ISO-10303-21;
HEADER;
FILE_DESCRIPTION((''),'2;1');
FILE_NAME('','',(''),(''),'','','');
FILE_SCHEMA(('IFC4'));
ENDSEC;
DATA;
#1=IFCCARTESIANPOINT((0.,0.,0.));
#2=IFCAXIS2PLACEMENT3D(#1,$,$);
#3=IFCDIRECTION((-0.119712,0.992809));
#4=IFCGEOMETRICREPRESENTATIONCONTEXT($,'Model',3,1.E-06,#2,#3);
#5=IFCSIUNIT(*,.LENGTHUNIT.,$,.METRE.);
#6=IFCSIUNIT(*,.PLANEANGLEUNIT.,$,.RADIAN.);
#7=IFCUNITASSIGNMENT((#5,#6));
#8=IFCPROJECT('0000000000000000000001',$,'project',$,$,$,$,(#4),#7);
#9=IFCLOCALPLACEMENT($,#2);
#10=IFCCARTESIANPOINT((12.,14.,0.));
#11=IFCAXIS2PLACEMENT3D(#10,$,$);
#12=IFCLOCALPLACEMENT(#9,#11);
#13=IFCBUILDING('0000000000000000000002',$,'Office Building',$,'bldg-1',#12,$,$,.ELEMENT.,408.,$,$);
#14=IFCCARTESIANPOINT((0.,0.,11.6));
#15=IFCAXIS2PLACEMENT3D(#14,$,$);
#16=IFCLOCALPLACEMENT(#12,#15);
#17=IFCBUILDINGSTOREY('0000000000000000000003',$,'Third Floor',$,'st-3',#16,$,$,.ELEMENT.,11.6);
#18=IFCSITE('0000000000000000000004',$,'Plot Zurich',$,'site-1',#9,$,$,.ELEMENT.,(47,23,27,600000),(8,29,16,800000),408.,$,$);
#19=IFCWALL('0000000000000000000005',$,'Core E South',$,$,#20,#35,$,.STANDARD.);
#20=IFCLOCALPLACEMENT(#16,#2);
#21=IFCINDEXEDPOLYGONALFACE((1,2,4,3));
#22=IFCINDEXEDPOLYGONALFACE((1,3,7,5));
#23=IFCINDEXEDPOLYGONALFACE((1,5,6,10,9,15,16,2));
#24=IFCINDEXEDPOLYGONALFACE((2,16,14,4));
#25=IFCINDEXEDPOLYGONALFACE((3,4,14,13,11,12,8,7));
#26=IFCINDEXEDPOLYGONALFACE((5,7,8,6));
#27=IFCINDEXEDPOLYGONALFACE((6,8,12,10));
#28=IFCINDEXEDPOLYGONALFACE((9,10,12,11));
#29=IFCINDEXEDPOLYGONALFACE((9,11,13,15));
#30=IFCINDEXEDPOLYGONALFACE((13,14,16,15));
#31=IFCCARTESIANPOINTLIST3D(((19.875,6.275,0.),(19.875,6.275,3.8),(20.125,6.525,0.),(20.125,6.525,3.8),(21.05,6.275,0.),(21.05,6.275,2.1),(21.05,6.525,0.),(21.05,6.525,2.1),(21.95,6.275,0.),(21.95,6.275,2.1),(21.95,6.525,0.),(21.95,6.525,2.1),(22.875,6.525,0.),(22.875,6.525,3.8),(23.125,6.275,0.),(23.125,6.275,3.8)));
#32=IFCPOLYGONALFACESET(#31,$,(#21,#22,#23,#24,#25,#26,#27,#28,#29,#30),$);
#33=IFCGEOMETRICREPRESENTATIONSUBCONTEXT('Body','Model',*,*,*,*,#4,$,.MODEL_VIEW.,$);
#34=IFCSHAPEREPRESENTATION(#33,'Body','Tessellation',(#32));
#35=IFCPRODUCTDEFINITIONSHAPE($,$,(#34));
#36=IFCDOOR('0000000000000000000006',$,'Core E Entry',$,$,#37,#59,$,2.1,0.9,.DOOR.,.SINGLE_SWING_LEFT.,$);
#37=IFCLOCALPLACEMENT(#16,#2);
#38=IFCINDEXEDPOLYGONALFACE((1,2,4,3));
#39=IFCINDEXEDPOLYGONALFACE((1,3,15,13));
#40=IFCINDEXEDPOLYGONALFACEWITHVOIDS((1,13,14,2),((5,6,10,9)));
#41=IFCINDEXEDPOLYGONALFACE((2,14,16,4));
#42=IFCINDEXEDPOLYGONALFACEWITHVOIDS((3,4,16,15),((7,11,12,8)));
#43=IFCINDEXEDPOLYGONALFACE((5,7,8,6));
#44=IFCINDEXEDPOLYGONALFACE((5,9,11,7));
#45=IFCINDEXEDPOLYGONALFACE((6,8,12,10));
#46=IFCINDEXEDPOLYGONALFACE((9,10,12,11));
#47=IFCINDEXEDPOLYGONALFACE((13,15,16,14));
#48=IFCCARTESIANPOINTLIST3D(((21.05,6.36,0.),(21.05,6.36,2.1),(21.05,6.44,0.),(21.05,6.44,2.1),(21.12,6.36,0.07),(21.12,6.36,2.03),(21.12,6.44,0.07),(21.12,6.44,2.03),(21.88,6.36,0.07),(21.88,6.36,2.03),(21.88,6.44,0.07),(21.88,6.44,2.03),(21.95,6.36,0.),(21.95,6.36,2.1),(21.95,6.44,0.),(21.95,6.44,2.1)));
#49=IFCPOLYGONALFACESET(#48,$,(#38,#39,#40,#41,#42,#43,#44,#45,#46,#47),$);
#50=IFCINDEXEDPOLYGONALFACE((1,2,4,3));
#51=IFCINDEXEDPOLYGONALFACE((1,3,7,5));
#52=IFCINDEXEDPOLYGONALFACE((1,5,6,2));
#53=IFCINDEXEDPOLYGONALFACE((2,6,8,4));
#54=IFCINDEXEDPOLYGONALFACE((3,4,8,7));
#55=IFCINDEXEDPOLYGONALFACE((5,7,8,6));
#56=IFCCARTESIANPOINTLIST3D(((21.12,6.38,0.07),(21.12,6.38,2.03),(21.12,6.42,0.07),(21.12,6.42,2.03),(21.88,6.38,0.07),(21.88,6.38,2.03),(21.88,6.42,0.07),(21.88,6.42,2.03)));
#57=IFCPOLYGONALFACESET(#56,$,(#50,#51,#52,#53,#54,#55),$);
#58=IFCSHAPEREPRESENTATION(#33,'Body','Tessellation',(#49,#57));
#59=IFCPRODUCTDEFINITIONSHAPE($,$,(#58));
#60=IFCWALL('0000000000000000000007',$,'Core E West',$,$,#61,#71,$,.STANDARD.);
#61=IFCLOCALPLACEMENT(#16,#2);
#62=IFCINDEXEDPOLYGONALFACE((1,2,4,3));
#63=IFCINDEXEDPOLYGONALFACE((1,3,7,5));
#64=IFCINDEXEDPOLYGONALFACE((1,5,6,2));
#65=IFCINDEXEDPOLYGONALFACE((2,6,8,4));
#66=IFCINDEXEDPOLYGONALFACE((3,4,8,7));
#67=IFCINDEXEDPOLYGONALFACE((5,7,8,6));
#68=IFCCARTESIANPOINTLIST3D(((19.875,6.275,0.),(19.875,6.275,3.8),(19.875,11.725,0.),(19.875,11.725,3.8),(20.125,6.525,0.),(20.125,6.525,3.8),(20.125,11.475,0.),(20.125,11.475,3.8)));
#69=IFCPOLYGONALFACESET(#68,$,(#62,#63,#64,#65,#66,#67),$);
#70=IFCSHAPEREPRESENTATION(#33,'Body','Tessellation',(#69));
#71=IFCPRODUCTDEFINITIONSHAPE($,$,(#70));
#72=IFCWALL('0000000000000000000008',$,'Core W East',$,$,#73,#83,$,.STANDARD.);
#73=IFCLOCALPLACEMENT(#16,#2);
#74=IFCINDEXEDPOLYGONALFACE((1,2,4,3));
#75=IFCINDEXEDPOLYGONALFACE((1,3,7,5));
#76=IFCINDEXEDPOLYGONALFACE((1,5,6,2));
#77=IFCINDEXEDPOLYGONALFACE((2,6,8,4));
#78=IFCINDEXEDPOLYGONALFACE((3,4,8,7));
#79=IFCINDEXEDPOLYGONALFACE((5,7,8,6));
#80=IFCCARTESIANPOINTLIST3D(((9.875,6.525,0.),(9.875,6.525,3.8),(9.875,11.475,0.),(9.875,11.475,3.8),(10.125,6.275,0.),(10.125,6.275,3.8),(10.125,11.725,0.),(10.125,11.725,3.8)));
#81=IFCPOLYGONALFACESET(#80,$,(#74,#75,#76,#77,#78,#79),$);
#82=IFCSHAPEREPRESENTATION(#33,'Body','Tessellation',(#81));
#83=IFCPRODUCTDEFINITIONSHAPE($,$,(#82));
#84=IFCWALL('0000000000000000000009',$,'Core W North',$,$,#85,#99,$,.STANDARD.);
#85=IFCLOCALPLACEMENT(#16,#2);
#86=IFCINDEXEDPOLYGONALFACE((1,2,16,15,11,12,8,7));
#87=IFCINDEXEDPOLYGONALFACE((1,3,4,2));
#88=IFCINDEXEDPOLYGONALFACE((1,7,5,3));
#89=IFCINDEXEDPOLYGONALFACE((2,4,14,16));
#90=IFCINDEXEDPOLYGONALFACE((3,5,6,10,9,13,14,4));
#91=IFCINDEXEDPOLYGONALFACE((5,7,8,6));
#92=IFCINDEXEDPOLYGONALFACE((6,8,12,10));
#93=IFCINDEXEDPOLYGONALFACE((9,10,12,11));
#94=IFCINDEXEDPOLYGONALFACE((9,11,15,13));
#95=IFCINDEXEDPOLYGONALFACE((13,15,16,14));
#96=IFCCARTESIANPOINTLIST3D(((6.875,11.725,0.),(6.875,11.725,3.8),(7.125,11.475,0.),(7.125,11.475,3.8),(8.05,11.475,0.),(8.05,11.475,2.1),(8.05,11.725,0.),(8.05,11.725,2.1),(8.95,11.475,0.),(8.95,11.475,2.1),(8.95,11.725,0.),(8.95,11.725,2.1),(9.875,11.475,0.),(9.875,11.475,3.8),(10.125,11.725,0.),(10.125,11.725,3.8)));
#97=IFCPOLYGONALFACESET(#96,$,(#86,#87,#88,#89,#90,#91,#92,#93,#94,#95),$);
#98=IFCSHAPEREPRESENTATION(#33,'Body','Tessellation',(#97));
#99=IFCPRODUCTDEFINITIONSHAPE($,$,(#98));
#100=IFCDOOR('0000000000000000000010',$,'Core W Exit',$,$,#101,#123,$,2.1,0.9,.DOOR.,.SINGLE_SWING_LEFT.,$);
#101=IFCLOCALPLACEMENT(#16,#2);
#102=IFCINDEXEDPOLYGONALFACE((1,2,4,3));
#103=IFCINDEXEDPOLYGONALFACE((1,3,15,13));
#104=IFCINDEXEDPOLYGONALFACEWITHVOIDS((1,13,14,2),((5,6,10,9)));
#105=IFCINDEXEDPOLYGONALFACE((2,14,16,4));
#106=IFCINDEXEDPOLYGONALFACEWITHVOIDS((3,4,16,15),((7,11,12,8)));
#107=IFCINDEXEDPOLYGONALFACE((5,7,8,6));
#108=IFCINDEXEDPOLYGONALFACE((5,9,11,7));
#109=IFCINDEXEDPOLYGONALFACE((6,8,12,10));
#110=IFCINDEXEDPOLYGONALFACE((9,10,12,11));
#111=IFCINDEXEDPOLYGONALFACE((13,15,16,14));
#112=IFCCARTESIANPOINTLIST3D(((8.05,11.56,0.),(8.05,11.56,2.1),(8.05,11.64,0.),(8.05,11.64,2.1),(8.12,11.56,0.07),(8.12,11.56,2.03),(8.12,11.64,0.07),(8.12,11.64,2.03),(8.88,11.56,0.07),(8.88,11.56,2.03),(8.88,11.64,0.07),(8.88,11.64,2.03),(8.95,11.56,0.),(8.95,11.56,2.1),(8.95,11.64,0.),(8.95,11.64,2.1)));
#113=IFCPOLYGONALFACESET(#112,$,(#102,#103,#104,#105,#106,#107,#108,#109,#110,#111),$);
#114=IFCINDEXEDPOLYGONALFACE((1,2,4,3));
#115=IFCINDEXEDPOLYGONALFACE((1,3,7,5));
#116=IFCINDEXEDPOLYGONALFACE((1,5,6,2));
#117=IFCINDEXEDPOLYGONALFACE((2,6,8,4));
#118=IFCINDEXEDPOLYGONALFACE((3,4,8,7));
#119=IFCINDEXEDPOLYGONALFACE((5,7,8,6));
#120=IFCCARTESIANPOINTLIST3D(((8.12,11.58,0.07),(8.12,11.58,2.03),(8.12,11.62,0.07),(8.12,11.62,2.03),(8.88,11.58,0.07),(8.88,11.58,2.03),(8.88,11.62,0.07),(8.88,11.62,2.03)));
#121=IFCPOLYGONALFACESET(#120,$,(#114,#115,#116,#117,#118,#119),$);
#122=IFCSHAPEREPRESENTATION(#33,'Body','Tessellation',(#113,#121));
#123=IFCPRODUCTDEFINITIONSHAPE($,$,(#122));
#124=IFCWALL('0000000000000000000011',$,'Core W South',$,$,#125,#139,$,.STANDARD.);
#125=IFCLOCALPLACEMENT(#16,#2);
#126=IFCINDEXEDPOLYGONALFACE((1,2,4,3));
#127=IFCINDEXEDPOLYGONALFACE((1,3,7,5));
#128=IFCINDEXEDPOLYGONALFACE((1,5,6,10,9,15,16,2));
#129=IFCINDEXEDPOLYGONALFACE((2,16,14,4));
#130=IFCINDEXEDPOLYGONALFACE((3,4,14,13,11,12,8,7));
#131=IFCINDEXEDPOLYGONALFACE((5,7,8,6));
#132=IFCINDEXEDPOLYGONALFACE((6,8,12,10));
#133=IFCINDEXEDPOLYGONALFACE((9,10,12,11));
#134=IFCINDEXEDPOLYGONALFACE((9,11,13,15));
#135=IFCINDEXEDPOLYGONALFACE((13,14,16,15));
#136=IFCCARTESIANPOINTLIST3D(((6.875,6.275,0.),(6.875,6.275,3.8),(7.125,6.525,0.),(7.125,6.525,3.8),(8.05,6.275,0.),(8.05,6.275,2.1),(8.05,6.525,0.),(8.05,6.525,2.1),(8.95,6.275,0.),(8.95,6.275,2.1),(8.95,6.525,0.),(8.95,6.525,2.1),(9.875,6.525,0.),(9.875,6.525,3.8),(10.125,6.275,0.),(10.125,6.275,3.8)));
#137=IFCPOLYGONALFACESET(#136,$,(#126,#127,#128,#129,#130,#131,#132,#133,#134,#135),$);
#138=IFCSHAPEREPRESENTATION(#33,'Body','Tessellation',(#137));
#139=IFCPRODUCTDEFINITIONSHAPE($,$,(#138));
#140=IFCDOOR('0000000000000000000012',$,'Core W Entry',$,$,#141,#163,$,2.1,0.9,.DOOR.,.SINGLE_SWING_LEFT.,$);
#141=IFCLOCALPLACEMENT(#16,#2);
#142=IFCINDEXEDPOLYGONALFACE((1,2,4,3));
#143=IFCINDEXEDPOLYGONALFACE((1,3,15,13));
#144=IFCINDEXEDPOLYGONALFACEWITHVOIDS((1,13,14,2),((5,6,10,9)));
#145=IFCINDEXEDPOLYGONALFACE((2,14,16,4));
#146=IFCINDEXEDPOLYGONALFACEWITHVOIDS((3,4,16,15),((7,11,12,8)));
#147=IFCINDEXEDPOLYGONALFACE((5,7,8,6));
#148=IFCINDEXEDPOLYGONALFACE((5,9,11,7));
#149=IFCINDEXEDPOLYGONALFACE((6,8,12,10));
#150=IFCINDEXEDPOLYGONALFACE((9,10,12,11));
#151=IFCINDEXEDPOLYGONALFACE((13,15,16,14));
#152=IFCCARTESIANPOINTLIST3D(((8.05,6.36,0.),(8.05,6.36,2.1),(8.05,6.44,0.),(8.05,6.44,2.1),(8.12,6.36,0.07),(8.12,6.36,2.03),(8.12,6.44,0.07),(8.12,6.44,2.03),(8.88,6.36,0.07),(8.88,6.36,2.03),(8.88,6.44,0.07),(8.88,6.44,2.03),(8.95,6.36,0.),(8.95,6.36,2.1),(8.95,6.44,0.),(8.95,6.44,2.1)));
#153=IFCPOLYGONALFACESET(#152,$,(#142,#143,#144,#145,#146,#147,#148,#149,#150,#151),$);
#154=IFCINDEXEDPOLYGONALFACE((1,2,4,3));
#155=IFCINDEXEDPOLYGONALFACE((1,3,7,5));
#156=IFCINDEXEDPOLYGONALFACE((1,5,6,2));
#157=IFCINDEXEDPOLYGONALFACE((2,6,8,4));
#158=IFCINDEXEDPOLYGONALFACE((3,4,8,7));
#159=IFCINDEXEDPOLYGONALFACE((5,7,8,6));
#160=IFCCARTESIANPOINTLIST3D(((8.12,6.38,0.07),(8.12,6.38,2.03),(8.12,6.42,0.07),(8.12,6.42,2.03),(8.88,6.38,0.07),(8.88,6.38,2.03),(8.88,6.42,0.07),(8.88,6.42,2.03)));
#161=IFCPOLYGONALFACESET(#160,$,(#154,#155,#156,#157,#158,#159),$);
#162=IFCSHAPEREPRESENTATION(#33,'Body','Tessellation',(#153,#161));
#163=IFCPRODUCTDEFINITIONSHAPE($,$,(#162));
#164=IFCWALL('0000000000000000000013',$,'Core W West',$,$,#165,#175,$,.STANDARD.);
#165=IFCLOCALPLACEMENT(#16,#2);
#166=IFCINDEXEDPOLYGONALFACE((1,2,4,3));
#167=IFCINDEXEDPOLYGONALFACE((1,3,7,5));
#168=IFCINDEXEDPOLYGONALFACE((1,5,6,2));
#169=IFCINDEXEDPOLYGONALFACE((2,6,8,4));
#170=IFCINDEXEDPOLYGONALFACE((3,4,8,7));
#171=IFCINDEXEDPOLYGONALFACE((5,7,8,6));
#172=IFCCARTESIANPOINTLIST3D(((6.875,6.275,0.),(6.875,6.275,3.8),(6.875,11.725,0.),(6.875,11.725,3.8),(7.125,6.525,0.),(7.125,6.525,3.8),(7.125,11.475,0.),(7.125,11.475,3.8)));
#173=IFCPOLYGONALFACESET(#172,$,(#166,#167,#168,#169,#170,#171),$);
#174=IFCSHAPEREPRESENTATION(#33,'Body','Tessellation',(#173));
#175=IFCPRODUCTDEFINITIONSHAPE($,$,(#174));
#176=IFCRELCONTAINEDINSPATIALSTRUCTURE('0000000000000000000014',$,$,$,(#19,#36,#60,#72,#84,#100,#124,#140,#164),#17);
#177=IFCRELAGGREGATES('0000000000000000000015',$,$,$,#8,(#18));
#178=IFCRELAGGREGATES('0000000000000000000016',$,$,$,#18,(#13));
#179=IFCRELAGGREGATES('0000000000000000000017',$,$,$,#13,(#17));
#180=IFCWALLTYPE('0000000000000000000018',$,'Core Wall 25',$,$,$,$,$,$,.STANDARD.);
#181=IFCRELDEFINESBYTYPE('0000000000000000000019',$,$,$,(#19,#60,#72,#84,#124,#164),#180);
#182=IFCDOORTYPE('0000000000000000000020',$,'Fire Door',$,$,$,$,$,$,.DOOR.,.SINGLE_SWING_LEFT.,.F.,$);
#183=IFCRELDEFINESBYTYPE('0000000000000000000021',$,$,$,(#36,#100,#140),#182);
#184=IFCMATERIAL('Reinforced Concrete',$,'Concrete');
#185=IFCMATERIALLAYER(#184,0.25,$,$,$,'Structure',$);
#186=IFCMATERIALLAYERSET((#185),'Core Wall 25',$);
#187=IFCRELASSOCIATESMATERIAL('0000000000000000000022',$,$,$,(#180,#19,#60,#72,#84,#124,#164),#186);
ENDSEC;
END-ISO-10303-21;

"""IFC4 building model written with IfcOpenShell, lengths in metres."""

from ifc_helpers import new_model, si_unit, direction, frame, frame_2d, origin, origin_2d, place, context, subcontext, project, spatial, polyline, rectangle, outline, extrude, material, layer, layer_set, layer_usage, type_object, element, fill, save


model = new_model("IFC4")

# Units and contexts
model_context = context("Model", 3, precision=1e-06, world=origin(), true_north=direction((-0.119712, 0.992809)))
body_context = subcontext(model_context, "Body", "Model", "MODEL_VIEW")
ifc_project = project(units=[si_unit("LENGTHUNIT", "METRE"), si_unit("PLANEANGLEUNIT", "RADIAN")], contexts=[model_context])

# Site, building, storey
site_placement = place(None, origin())
site = spatial("IfcSite", under=ifc_project, at=site_placement, Name="Plot Zurich", ObjectType="site-1", CompositionType="ELEMENT", RefLatitude=(47, 23, 27, 600000), RefLongitude=(8, 29, 16, 800000), RefElevation=408.0)
building_placement = place(site_placement, frame((12.0, 14.0, 0.0)))
building = spatial("IfcBuilding", under=site, at=building_placement, Name="Office Building", ObjectType="bldg-1", CompositionType="ELEMENT", ElevationOfRefHeight=408.0)
storey_placement = place(building_placement, frame((0.0, 0.0, 11.6)))
storey = spatial("IfcBuildingStorey", under=building, at=storey_placement, Name="Third Floor", ObjectType="st-3", CompositionType="ELEMENT", Elevation=11.6)

# Shared definitions
ifc_material_1 = material(Name="Reinforced Concrete", Category="Concrete")

# Shared definitions
ifc_layer_1 = layer(ifc_material_1, 0.25, Category="Structure")
ifc_layer_set_1 = layer_set([ifc_layer_1], Name="Core Wall 25")
wall_type_1 = type_object("IfcWallType", Name="Core Wall 25", PredefinedType="STANDARD", material=ifc_layer_set_1)

# Wall, opening, door
door_type = type_object("IfcDoorType", Name="Fire Door", OperationType="SINGLE_SWING_LEFT", ParameterTakesPrecedence=False, PredefinedType="DOOR")
ifc_layer_usage_1 = layer_usage(ifc_layer_set_1, "AXIS2", "NEGATIVE", 0.125)
wall_1_placement = place(storey_placement, origin())
wall_1 = element("IfcWall", 1, at=wall_1_placement, inside=storey, type_object=wall_type_1, material=ifc_layer_usage_1, Name="Core E South", PredefinedType="STANDARD", context=body_context, shape_type="SweptSolid", body=[
    extrude(outline(polyline([(19.875, 6.275), (23.125, 6.275), (22.875, 6.525), (20.125, 6.525), (19.875, 6.275)])), origin(), (0.0, 0.0, 1.0), 3.8),
])
opening_1_placement = place(wall_1_placement, frame((21.5, 6.4, 0.0), z_axis=(0.0, 0.0, 1.0), x_axis=(1.0, 0.0, 0.0)))
opening_1 = element("IfcOpeningElement", 2, at=opening_1_placement, cuts=wall_1, PredefinedType="OPENING", context=body_context, shape_type="SweptSolid", body=[
    extrude(rectangle(XDim=0.9, YDim=0.25, at=origin_2d()), origin(), (0.0, 0.0, 1.0), 2.1),
])
door_1_placement = place(opening_1_placement, frame((0.0, 0.0, 0.0), z_axis=(0.0, -1.0, 0.0), x_axis=(1.0, 0.0, 0.0)))
door_1 = element("IfcDoor", 3, at=door_1_placement, inside=storey, type_object=door_type, Name="Core E Entry", OperationType="SINGLE_SWING_LEFT", OverallHeight=2.1, OverallWidth=0.9, PredefinedType="DOOR", context=body_context, shape_type="SweptSolid", body=[
    extrude(outline(polyline([(-0.45, 0.0), (0.45, 0.0), (0.45, 2.1), (-0.45, 2.1), (-0.45, 0.0)]), holes=[polyline([(-0.38, 0.07), (0.38, 0.07), (0.38, 2.03), (-0.38, 2.03), (-0.38, 0.07)])]), frame((0.0, 0.0, -0.04)), (0.0, 0.0, 1.0), 0.08),
    extrude(rectangle(XDim=0.76, YDim=1.96, at=frame_2d((0.0, 1.05))), frame((0.0, 0.0, -0.02)), (0.0, 0.0, 1.0), 0.04),
])
fill(opening_1, door_1)

# Walls
ifc_layer_usage_2 = layer_usage(ifc_layer_set_1, "AXIS2", "NEGATIVE", 0.125)
wall_2_placement = place(storey_placement, origin())
element("IfcWall", 4, at=wall_2_placement, inside=storey, type_object=wall_type_1, material=ifc_layer_usage_2, Name="Core E West", PredefinedType="STANDARD", context=body_context, shape_type="SweptSolid", body=[
    extrude(outline(polyline([(19.875, 11.725), (19.875, 6.275), (20.125, 6.525), (20.125, 11.475), (19.875, 11.725)])), origin(), (0.0, 0.0, 1.0), 3.8),
])
ifc_layer_usage_3 = layer_usage(ifc_layer_set_1, "AXIS2", "NEGATIVE", 0.125)
wall_3_placement = place(storey_placement, origin())
element("IfcWall", 5, at=wall_3_placement, inside=storey, type_object=wall_type_1, material=ifc_layer_usage_3, Name="Core W East", PredefinedType="STANDARD", context=body_context, shape_type="SweptSolid", body=[
    extrude(outline(polyline([(10.125, 6.275), (10.125, 11.725), (9.875, 11.475), (9.875, 6.525), (10.125, 6.275)])), origin(), (0.0, 0.0, 1.0), 3.8),
])

# Walls, openings, doors
ifc_layer_usage_4 = layer_usage(ifc_layer_set_1, "AXIS2", "NEGATIVE", 0.125)
wall_4_placement = place(storey_placement, origin())
wall_4 = element("IfcWall", 6, at=wall_4_placement, inside=storey, type_object=wall_type_1, material=ifc_layer_usage_4, Name="Core W North", PredefinedType="STANDARD", context=body_context, shape_type="SweptSolid", body=[
    extrude(outline(polyline([(10.125, 11.725), (6.875, 11.725), (7.125, 11.475), (9.875, 11.475), (10.125, 11.725)])), origin(), (0.0, 0.0, 1.0), 3.8),
])
opening_2_placement = place(wall_4_placement, frame((8.5, 11.6, 0.0), z_axis=(0.0, 0.0, 1.0), x_axis=(-1.0, 0.0, 0.0)))
opening_2 = element("IfcOpeningElement", 7, at=opening_2_placement, cuts=wall_4, PredefinedType="OPENING", context=body_context, shape_type="SweptSolid", body=[
    extrude(rectangle(XDim=0.9, YDim=0.25, at=origin_2d()), origin(), (0.0, 0.0, 1.0), 2.1),
])
door_2_placement = place(opening_2_placement, frame((0.0, 0.0, 0.0), z_axis=(0.0, -1.0, 0.0), x_axis=(1.0, 0.0, 0.0)))
door_2 = element("IfcDoor", 8, at=door_2_placement, inside=storey, type_object=door_type, Name="Core W Exit", OperationType="SINGLE_SWING_LEFT", OverallHeight=2.1, OverallWidth=0.9, PredefinedType="DOOR", context=body_context, shape_type="SweptSolid", body=[
    extrude(outline(polyline([(-0.45, 0.0), (0.45, 0.0), (0.45, 2.1), (-0.45, 2.1), (-0.45, 0.0)]), holes=[polyline([(-0.38, 0.07), (0.38, 0.07), (0.38, 2.03), (-0.38, 2.03), (-0.38, 0.07)])]), frame((0.0, 0.0, -0.04)), (0.0, 0.0, 1.0), 0.08),
    extrude(rectangle(XDim=0.76, YDim=1.96, at=frame_2d((0.0, 1.05))), frame((0.0, 0.0, -0.02)), (0.0, 0.0, 1.0), 0.04),
])
fill(opening_2, door_2)
ifc_layer_usage_5 = layer_usage(ifc_layer_set_1, "AXIS2", "NEGATIVE", 0.125)
wall_5_placement = place(storey_placement, origin())
wall_5 = element("IfcWall", 9, at=wall_5_placement, inside=storey, type_object=wall_type_1, material=ifc_layer_usage_5, Name="Core W South", PredefinedType="STANDARD", context=body_context, shape_type="SweptSolid", body=[
    extrude(outline(polyline([(6.875, 6.275), (10.125, 6.275), (9.875, 6.525), (7.125, 6.525), (6.875, 6.275)])), origin(), (0.0, 0.0, 1.0), 3.8),
])
opening_3_placement = place(wall_5_placement, frame((8.5, 6.4, 0.0), z_axis=(0.0, 0.0, 1.0), x_axis=(1.0, 0.0, 0.0)))
opening_3 = element("IfcOpeningElement", 10, at=opening_3_placement, cuts=wall_5, PredefinedType="OPENING", context=body_context, shape_type="SweptSolid", body=[
    extrude(rectangle(XDim=0.9, YDim=0.25, at=origin_2d()), origin(), (0.0, 0.0, 1.0), 2.1),
])
door_3_placement = place(opening_3_placement, frame((0.0, 0.0, 0.0), z_axis=(0.0, -1.0, 0.0), x_axis=(1.0, 0.0, 0.0)))
door_3 = element("IfcDoor", 11, at=door_3_placement, inside=storey, type_object=door_type, Name="Core W Entry", OperationType="SINGLE_SWING_LEFT", OverallHeight=2.1, OverallWidth=0.9, PredefinedType="DOOR", context=body_context, shape_type="SweptSolid", body=[
    extrude(outline(polyline([(-0.45, 0.0), (0.45, 0.0), (0.45, 2.1), (-0.45, 2.1), (-0.45, 0.0)]), holes=[polyline([(-0.38, 0.07), (0.38, 0.07), (0.38, 2.03), (-0.38, 2.03), (-0.38, 0.07)])]), frame((0.0, 0.0, -0.04)), (0.0, 0.0, 1.0), 0.08),
    extrude(rectangle(XDim=0.76, YDim=1.96, at=frame_2d((0.0, 1.05))), frame((0.0, 0.0, -0.02)), (0.0, 0.0, 1.0), 0.04),
])
fill(opening_3, door_3)

# Wall
ifc_layer_usage_6 = layer_usage(ifc_layer_set_1, "AXIS2", "NEGATIVE", 0.125)
wall_6_placement = place(storey_placement, origin())
element("IfcWall", 12, at=wall_6_placement, inside=storey, type_object=wall_type_1, material=ifc_layer_usage_6, Name="Core W West", PredefinedType="STANDARD", context=body_context, shape_type="SweptSolid", body=[
    extrude(outline(polyline([(6.875, 11.725), (6.875, 6.275), (7.125, 6.525), (7.125, 11.475), (6.875, 11.725)])), origin(), (0.0, 0.0, 1.0), 3.8),
])

save(model, "model.ifc")
